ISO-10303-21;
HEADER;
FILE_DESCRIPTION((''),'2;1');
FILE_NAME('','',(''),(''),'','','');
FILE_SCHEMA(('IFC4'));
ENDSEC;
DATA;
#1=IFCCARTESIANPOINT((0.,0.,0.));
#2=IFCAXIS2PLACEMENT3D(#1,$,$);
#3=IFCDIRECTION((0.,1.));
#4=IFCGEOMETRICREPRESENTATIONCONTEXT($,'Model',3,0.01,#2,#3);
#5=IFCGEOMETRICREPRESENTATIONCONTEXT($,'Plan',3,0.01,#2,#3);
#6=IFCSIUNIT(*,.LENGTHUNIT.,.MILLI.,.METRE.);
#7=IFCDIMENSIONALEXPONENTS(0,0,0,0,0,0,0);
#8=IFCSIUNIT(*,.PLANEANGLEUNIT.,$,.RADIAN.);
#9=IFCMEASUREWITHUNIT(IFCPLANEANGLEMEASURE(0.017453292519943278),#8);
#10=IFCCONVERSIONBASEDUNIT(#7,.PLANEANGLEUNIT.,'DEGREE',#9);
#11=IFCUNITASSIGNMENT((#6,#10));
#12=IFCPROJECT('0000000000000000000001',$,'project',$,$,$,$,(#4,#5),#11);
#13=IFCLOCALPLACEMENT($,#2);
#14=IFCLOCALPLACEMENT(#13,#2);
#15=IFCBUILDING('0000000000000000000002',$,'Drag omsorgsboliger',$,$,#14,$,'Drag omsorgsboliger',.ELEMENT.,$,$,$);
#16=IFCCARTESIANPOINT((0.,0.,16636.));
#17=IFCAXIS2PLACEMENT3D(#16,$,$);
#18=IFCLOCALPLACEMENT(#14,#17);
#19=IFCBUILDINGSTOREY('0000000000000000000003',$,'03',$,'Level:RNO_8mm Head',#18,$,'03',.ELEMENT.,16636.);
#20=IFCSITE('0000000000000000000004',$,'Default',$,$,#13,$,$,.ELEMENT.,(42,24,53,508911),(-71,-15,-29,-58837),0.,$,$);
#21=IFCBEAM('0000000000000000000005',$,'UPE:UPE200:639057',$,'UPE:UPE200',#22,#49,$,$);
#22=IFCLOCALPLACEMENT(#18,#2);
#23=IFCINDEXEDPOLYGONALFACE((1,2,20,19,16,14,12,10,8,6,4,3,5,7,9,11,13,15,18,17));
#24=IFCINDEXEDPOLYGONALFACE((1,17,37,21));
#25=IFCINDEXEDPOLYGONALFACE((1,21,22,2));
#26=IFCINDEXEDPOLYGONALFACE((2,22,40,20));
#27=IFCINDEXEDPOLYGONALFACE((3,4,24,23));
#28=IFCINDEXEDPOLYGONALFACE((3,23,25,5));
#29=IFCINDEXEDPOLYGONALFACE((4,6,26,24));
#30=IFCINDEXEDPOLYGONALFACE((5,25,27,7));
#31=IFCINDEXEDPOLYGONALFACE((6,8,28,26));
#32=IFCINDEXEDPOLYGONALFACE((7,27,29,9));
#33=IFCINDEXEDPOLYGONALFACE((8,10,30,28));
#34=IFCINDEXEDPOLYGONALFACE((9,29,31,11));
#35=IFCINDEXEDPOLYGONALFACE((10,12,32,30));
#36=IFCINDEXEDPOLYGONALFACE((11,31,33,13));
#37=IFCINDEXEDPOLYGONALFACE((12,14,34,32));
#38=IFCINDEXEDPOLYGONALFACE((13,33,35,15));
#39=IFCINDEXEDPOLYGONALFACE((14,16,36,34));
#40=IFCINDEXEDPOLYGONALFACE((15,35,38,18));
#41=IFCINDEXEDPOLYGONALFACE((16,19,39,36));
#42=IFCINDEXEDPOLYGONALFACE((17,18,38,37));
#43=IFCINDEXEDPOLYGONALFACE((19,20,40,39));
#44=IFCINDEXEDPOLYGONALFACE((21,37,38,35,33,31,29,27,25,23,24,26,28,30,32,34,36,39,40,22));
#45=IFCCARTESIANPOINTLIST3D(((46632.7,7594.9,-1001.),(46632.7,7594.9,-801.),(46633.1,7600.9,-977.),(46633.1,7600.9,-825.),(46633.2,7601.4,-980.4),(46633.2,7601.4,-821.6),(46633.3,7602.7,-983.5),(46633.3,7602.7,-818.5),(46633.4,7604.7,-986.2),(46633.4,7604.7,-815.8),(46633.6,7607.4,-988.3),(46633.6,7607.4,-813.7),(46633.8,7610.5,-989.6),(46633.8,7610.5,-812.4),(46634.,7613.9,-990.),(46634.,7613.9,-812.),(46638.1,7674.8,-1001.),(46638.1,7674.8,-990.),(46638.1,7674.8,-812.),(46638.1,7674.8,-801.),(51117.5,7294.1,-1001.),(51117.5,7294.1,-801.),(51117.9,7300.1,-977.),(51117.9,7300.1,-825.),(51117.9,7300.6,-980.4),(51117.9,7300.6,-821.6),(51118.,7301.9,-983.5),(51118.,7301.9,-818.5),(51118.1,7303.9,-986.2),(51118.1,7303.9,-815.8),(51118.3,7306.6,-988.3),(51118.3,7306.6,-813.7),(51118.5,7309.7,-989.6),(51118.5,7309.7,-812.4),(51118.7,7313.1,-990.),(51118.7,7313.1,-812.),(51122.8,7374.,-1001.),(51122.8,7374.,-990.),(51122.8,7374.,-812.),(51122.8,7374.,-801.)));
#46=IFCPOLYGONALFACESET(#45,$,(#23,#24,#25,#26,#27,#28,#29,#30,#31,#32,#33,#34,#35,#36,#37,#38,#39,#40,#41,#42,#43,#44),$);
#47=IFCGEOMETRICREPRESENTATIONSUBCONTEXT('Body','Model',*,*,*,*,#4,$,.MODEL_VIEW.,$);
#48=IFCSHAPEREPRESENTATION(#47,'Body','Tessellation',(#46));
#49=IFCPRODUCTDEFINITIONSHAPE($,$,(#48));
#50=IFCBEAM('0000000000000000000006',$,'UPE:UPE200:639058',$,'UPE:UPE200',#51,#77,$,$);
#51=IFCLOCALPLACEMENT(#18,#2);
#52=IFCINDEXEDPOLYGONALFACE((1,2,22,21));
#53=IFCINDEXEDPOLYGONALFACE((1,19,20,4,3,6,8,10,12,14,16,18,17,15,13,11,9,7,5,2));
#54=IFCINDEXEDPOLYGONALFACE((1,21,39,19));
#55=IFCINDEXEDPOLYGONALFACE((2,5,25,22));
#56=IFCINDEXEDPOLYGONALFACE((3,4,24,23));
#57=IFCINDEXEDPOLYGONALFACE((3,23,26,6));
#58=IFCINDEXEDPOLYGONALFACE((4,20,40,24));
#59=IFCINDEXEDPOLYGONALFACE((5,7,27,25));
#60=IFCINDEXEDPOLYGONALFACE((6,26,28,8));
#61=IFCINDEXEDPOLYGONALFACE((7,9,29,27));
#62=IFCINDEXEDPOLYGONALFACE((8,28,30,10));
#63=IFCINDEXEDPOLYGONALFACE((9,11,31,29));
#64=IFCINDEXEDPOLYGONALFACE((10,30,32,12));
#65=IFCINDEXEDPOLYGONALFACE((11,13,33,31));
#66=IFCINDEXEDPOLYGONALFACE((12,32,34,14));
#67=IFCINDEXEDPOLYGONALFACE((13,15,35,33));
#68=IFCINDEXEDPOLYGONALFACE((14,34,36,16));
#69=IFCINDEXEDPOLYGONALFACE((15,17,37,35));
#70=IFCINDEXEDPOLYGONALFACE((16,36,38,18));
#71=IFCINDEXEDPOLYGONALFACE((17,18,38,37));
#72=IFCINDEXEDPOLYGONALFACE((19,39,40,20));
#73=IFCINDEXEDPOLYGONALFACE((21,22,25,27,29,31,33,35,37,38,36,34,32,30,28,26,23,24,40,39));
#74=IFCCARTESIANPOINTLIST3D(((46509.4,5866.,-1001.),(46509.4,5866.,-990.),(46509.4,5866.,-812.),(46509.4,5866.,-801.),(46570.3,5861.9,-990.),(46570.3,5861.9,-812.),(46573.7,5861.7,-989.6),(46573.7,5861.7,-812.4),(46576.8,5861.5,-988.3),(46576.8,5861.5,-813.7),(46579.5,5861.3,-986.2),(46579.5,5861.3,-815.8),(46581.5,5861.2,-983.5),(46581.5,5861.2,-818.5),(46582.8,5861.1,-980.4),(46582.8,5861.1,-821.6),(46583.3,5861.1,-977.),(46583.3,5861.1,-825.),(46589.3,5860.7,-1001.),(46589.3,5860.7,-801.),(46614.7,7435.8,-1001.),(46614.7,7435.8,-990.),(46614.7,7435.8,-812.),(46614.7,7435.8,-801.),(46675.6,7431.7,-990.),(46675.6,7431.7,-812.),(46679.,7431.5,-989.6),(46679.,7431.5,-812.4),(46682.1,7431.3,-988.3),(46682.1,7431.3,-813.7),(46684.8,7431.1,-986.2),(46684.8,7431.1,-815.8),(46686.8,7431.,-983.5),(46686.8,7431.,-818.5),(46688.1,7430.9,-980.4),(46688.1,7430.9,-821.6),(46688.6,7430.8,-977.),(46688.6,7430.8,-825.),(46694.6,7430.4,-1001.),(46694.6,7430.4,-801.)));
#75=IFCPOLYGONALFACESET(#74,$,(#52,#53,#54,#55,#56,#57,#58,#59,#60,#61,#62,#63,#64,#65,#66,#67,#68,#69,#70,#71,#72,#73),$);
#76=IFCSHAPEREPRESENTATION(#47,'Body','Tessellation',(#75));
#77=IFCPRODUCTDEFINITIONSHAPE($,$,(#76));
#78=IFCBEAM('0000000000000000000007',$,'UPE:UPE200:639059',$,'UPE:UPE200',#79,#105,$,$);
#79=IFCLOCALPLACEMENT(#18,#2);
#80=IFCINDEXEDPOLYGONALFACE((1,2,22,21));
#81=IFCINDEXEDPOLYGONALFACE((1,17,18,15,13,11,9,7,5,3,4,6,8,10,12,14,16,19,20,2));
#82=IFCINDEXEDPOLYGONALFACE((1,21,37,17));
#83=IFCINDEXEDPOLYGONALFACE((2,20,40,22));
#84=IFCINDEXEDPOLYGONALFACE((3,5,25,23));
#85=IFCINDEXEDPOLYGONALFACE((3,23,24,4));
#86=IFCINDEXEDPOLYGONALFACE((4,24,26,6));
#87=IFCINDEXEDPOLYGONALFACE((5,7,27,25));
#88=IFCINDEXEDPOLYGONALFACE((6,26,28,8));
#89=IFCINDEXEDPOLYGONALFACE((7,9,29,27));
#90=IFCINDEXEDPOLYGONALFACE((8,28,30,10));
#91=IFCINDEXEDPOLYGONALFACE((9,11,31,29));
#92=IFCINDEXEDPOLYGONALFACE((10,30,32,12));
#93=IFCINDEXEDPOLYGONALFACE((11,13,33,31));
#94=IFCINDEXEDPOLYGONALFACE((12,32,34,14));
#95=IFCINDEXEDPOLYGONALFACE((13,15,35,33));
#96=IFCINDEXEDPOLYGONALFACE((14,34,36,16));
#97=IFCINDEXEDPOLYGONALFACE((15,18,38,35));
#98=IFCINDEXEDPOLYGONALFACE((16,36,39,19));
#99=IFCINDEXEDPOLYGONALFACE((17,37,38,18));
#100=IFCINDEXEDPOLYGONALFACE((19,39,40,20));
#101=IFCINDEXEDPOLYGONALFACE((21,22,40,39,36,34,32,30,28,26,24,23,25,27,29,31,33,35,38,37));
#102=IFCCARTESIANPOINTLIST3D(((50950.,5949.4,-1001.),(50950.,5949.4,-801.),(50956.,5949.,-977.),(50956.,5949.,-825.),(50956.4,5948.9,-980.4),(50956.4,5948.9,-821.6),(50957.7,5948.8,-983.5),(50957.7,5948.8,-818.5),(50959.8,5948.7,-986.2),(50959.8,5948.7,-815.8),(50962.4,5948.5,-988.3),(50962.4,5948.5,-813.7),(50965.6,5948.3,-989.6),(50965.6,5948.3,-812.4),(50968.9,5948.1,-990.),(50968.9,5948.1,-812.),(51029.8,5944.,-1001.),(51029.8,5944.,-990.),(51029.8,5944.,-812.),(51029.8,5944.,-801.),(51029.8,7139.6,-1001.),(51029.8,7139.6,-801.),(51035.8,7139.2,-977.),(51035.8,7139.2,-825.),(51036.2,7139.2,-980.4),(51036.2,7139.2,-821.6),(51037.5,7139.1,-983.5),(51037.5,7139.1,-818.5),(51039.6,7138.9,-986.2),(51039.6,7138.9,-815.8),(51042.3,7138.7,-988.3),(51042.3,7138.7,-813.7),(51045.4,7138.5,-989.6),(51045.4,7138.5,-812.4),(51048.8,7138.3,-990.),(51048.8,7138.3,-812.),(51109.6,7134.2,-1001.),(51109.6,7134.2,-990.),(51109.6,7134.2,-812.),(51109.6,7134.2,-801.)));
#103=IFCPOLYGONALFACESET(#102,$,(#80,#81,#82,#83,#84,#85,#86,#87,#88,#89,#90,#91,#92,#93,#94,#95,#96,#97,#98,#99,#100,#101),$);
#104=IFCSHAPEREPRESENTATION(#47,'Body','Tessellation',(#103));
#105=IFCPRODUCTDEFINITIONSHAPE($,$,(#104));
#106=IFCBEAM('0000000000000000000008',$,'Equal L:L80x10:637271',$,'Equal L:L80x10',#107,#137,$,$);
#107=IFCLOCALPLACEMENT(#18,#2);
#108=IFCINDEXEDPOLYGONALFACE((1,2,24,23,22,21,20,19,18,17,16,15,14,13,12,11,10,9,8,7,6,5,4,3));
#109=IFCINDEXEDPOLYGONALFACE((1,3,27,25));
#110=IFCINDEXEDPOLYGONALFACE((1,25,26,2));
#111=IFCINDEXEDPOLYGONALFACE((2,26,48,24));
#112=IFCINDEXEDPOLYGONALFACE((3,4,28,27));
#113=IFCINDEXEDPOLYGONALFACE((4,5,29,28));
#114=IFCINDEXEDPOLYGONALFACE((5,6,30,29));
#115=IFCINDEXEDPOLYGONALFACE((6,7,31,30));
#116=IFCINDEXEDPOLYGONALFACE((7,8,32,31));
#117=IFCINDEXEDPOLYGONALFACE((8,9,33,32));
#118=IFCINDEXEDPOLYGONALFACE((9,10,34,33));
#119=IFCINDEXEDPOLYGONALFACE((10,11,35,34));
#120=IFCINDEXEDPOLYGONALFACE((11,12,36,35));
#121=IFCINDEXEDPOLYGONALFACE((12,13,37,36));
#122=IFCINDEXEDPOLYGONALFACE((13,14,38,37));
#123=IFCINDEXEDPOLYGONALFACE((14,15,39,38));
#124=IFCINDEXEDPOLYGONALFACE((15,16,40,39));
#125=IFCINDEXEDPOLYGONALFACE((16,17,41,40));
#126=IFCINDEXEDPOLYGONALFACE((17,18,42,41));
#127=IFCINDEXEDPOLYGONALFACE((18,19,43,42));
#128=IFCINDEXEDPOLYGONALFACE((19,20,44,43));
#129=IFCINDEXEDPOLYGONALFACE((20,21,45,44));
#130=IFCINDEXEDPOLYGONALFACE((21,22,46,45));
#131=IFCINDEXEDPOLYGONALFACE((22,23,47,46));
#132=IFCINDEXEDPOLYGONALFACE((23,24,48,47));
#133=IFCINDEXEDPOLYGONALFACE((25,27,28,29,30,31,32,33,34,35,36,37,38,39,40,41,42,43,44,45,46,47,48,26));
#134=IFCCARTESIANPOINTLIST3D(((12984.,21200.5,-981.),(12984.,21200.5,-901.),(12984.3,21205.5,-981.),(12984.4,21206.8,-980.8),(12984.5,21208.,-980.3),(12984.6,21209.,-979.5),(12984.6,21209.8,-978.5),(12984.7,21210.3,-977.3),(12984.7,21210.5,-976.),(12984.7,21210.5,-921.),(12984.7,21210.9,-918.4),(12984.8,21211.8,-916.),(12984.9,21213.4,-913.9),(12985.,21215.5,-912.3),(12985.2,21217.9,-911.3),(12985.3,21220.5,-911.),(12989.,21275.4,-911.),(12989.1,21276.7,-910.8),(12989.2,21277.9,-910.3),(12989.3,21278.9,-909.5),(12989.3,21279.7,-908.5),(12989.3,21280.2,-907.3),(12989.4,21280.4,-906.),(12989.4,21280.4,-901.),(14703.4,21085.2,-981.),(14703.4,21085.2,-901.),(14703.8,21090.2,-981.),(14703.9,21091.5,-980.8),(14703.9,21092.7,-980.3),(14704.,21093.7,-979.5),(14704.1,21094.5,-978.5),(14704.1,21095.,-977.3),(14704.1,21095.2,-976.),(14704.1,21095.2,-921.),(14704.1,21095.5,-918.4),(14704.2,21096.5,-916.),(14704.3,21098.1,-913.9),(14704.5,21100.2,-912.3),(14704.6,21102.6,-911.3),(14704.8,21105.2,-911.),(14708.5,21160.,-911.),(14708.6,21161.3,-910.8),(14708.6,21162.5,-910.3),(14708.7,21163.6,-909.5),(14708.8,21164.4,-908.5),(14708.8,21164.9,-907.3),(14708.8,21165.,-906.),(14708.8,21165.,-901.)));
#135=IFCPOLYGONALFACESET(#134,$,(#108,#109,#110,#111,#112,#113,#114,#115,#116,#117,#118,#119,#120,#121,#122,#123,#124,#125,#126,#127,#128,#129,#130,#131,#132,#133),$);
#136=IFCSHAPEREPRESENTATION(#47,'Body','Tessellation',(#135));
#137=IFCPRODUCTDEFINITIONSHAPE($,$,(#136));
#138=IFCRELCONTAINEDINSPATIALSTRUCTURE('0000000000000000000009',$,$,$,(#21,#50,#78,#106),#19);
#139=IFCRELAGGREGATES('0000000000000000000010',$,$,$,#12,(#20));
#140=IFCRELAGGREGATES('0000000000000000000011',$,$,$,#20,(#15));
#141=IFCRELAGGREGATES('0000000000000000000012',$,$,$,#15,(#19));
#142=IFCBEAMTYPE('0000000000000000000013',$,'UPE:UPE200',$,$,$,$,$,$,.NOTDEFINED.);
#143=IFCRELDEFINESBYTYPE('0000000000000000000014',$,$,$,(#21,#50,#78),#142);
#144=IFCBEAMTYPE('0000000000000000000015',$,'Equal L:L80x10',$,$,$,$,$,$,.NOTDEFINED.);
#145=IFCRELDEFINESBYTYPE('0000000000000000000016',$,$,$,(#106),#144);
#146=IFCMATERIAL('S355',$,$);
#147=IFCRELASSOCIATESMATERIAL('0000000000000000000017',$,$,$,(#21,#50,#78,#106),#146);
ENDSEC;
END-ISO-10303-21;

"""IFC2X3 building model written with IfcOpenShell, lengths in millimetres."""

from ifc_helpers import new_model, entity, si_unit, converted_unit, direction, frame, frame_2d, origin, place, context, subcontext, project, spatial, polyline, circle_curve, parameter, trimmed, segment, composite_curve, outline, extrude, material, type_object, element, save


model = new_model("IFC2X3")

# Units and contexts
model_context = context("Model", 3, precision=0.01, world=origin(), true_north=direction((0.0, 1.0)))
plan_context = context("Plan", 3, precision=0.01, world=origin(), true_north=direction((0.0, 1.0)))
body_context = subcontext(model_context, "Body", "Model", "MODEL_VIEW")
ifc_project = project(units=[si_unit("LENGTHUNIT", "METRE", prefix="MILLI"), converted_unit("PLANEANGLEUNIT", "DEGREE", entity("IfcPlaneAngleMeasure", 0.017453292519943278), si_unit("PLANEANGLEUNIT", "RADIAN"), dimensions=[0, 0, 0, 0, 0, 0, 0])], contexts=[model_context, plan_context])

# Site, building, storey
site_placement = place(None, origin())
site = spatial("IfcSite", under=ifc_project, at=site_placement, Name="Default", CompositionType="ELEMENT", RefLatitude=(42, 24, 53, 508911), RefLongitude=(-71, -15, -29, -58837), RefElevation=0.0)
building_placement = place(site_placement, origin())
building = spatial("IfcBuilding", under=site, at=building_placement, Name="Drag omsorgsboliger", LongName="Drag omsorgsboliger", CompositionType="ELEMENT")
storey_placement = place(building_placement, frame((0.0, 0.0, 16636.0)))
storey = spatial("IfcBuildingStorey", under=building, at=storey_placement, Name="03", ObjectType="Level:RNO_8mm Head", LongName="03", CompositionType="ELEMENT", Elevation=16636.0)

# Beams
ifc_material = material(Name="S355")
beam_type_1 = type_object("IfcBeamType", Name="UPE:UPE200", PredefinedType="NOTDEFINED")
beam_1_placement = place(storey_placement, frame((46633.6, 7620.5, -801.0), z_axis=(0.0, 0.0, 1.0), x_axis=(0.997758, -0.066923, 0.0)))
element("IfcBeam", 1, at=beam_1_placement, inside=storey, type_object=beam_type_1, material=ifc_material, Name="UPE:UPE200:639057", ObjectType="UPE:UPE200", context=body_context, shape_type="SweptSolid", body=[
    extrude(outline(composite_curve([segment(polyline([(-100.0, -37.0), (100.0, -37.0)]), True, "CONTINUOUS"), segment(polyline([(100.0, -37.0), (100.0, 43.0)]), True, "CONTINUOUS"), segment(polyline([(100.0, 43.0), (89.0, 43.0)]), True, "CONTINUOUS"), segment(polyline([(89.0, 43.0), (89.0, -18.0)]), True, "CONTINUOUS"), segment(trimmed(circle_curve(frame_2d((76.0, -18.0), x_axis=(1.0, 0.0)), 13.0), [parameter(270.0)], [parameter(0.0)], True, "PARAMETER"), False, "CONTINUOUS"), segment(polyline([(76.0, -31.0), (-76.0, -31.0)]), True, "CONTINUOUS"), segment(trimmed(circle_curve(frame_2d((-76.0, -18.0), x_axis=(0.0, -1.0)), 13.0), [parameter(270.0)], [parameter(0.0)], True, "PARAMETER"), False, "CONTINUOUS"), segment(polyline([(-89.0, -18.0), (-89.0, 43.0)]), True, "CONTINUOUS"), segment(polyline([(-89.0, 43.0), (-100.0, 43.0)]), True, "CONTINUOUS"), segment(polyline([(-100.0, 43.0), (-100.0, -37.0)]), True, "CONTINUOUS")], self_intersect=False)), frame((0.8, 11.4, -100.0), z_axis=(1.0, 0.0, 0.0), x_axis=(0.0, 0.0, -1.0)), (0.0, 0.0, 1.0), 4494.8),
])
beam_2_placement = place(storey_placement, frame((46669.0, 7432.2, -801.0), z_axis=(0.0, 0.0, 1.0), x_axis=(-0.066923, -0.997758, 0.0)))
element("IfcBeam", 2, at=beam_2_placement, inside=storey, type_object=beam_type_1, material=ifc_material, Name="UPE:UPE200:639058", ObjectType="UPE:UPE200", context=body_context, shape_type="SweptSolid", body=[
    extrude(outline(composite_curve([segment(polyline([(-100.0, -43.0), (-89.0, -43.0)]), True, "CONTINUOUS"), segment(polyline([(-89.0, -43.0), (-89.0, 18.0)]), True, "CONTINUOUS"), segment(trimmed(circle_curve(frame_2d((-76.0, 18.0), x_axis=(-1.0, 0.0)), 13.0), [parameter(270.0)], [parameter(0.0)], True, "PARAMETER"), False, "CONTINUOUS"), segment(polyline([(-76.0, 31.0), (76.0, 31.0)]), True, "CONTINUOUS"), segment(trimmed(circle_curve(frame_2d((76.0, 18.0), x_axis=(0.0, 1.0)), 13.0), [parameter(270.0)], [parameter(0.0)], True, "PARAMETER"), False, "CONTINUOUS"), segment(polyline([(89.0, 18.0), (89.0, -43.0)]), True, "CONTINUOUS"), segment(polyline([(89.0, -43.0), (100.0, -43.0)]), True, "CONTINUOUS"), segment(polyline([(100.0, -43.0), (100.0, 37.0)]), True, "CONTINUOUS"), segment(polyline([(100.0, 37.0), (-100.0, 37.0)]), True, "CONTINUOUS"), segment(polyline([(-100.0, 37.0), (-100.0, -43.0)]), True, "CONTINUOUS")], self_intersect=False)), frame((0.0, -11.4, -100.0), z_axis=(1.0, 0.0, 0.0), x_axis=(0.0, 0.0, -1.0)), (0.0, 0.0, 1.0), 1573.3),
])
beam_3_placement = place(storey_placement, frame((51060.7, 7218.2, -801.0), z_axis=(0.0, 0.0, 1.0), x_axis=(-0.066923, -0.997758, 0.0)))
element("IfcBeam", 3, at=beam_3_placement, inside=storey, type_object=beam_type_1, material=ifc_material, Name="UPE:UPE200:639059", ObjectType="UPE:UPE200", context=body_context, shape_type="SweptSolid", body=[
    extrude(outline(composite_curve([segment(polyline([(-100.0, -37.0), (100.0, -37.0)]), True, "CONTINUOUS"), segment(polyline([(100.0, -37.0), (100.0, 43.0)]), True, "CONTINUOUS"), segment(polyline([(100.0, 43.0), (89.0, 43.0)]), True, "CONTINUOUS"), segment(polyline([(89.0, 43.0), (89.0, -18.0)]), True, "CONTINUOUS"), segment(trimmed(circle_curve(frame_2d((76.0, -18.0), x_axis=(1.0, 0.0)), 13.0), [parameter(270.0)], [parameter(0.0)], True, "PARAMETER"), False, "CONTINUOUS"), segment(polyline([(76.0, -31.0), (-76.0, -31.0)]), True, "CONTINUOUS"), segment(trimmed(circle_curve(frame_2d((-76.0, -18.0), x_axis=(0.0, -1.0)), 13.0), [parameter(270.0)], [parameter(0.0)], True, "PARAMETER"), False, "CONTINUOUS"), segment(polyline([(-89.0, -18.0), (-89.0, 43.0)]), True, "CONTINUOUS"), segment(polyline([(-89.0, 43.0), (-100.0, 43.0)]), True, "CONTINUOUS"), segment(polyline([(-100.0, 43.0), (-100.0, -37.0)]), True, "CONTINUOUS")], self_intersect=False)), frame((80.5, 11.4, -100.0), z_axis=(1.0, 0.0, 0.0), x_axis=(0.0, 0.0, -1.0)), (0.0, 0.0, 1.0), 1192.9),
])
beam_type_2 = type_object("IfcBeamType", Name="Equal L:L80x10", PredefinedType="NOTDEFINED")
beam_4_placement = place(storey_placement, frame((14635.2, 21113.2, -981.0), z_axis=(0.0, 0.0, 1.0), x_axis=(-0.997758, 0.066923, 0.0)))
element("IfcBeam", 4, at=beam_4_placement, inside=storey, type_object=beam_type_2, material=ifc_material, Name="Equal L:L80x10:637271", ObjectType="Equal L:L80x10", context=body_context, shape_type="SweptSolid", body=[
    extrude(outline(composite_curve([segment(polyline([(-31.1, -48.9), (-26.1, -48.9)]), True, "CONTINUOUS"), segment(trimmed(circle_curve(frame_2d((-26.1, -43.9), x_axis=(0.0, -1.0)), 5.0), [parameter(0.0)], [parameter(90.0)], True, "PARAMETER"), True, "CONTINUOUS"), segment(polyline([(-21.1, -43.9), (-21.1, 11.1)]), True, "CONTINUOUS"), segment(trimmed(circle_curve(frame_2d((-11.1, 11.1), x_axis=(-1.0, 0.0)), 10.0), [parameter(270.0)], [parameter(0.0)], True, "PARAMETER"), False, "CONTINUOUS"), segment(polyline([(-11.1, 21.1), (43.9, 21.1)]), True, "CONTINUOUS"), segment(trimmed(circle_curve(frame_2d((43.9, 26.1), x_axis=(0.0, -1.0)), 5.0), [parameter(0.0)], [parameter(90.0)], True, "PARAMETER"), True, "CONTINUOUS"), segment(polyline([(48.9, 26.1), (48.9, 31.1)]), True, "CONTINUOUS"), segment(polyline([(48.9, 31.1), (-31.1, 31.1)]), True, "CONTINUOUS"), segment(polyline([(-31.1, 31.1), (-31.1, -48.9)]), True, "CONTINUOUS")], self_intersect=False)), frame((-70.0, -7.7, 48.9), z_axis=(1.0, 0.0, 0.0), x_axis=(0.0, 0.0, -1.0)), (0.0, 0.0, 1.0), 1723.3),
])

save(model, "model.ifc")
